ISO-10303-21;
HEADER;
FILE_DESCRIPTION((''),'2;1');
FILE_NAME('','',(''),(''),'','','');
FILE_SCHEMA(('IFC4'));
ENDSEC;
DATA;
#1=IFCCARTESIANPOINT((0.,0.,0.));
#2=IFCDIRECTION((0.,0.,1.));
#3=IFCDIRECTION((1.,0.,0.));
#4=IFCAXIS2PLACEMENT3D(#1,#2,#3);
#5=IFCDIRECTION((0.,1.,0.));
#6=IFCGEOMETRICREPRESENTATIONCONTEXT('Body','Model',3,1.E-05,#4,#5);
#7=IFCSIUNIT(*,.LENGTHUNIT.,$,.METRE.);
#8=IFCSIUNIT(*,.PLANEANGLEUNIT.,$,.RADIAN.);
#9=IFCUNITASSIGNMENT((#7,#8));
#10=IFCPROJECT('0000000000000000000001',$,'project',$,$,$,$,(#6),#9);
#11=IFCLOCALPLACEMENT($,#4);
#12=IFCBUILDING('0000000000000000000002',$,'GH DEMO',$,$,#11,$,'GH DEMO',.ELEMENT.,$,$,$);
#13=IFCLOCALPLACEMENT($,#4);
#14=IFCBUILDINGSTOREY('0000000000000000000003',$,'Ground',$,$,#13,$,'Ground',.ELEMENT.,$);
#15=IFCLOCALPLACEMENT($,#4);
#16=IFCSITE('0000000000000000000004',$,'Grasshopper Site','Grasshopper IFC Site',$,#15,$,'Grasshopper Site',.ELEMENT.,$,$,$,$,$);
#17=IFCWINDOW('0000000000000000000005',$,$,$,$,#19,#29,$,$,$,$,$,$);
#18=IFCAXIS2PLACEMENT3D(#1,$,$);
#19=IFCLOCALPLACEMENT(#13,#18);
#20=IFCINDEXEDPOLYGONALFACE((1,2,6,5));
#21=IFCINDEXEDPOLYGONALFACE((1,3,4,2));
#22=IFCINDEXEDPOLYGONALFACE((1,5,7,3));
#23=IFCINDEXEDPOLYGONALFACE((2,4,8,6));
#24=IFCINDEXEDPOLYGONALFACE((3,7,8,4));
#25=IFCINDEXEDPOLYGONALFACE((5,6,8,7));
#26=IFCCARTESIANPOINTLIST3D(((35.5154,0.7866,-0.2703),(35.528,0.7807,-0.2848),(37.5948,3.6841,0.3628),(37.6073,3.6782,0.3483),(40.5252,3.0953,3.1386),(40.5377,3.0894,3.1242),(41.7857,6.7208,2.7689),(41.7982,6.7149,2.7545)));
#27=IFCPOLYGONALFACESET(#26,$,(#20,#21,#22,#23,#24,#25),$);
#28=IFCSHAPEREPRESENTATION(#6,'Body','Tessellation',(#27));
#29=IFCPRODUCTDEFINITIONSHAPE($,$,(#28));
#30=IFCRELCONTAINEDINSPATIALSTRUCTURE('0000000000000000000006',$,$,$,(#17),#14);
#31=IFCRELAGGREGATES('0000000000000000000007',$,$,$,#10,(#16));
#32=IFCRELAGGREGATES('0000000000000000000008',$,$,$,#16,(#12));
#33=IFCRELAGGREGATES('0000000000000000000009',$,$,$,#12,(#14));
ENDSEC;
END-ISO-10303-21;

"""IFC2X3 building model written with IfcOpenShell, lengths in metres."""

from ifc_helpers import new_model, si_unit, direction, frame, origin_with_axes, place, context, project, spatial, polyline, outline, extrude, element, save


model = new_model("IFC2X3")

# Units and contexts
model_context = context("Model", 3, precision=1e-05, world=origin_with_axes(), true_north=direction((0.0, 1.0, 0.0)), identifier="Body")
ifc_project = project(units=[si_unit("LENGTHUNIT", "METRE"), si_unit("PLANEANGLEUNIT", "RADIAN")], contexts=[model_context])

# Site, building, storey
site_placement = place(None, origin_with_axes())
site = spatial("IfcSite", under=ifc_project, at=site_placement, Name="Grasshopper Site", Description="Grasshopper IFC Site", LongName="Grasshopper Site", CompositionType="ELEMENT")
building_placement = place(None, origin_with_axes())
building = spatial("IfcBuilding", under=site, at=building_placement, Name="GH DEMO", LongName="GH DEMO", CompositionType="ELEMENT")
storey_placement = place(None, origin_with_axes())
storey = spatial("IfcBuildingStorey", under=building, at=storey_placement, Name="Ground", LongName="Ground", CompositionType="ELEMENT")

# Window
window_1_placement = place(None, origin_with_axes())
element("IfcWindow", 1, at=window_1_placement, inside=storey, context=model_context, shape_type="SweptSolid", body=[
    extrude(outline(polyline([(0.0, 0.0), (5.7074, 0.0), (3.0087, 2.7544), (-3.3354, 1.4125), (0.0, 0.0)])), frame((37.5948, 3.6841, 0.3628), z_axis=(0.626319, -0.291483, -0.723023), x_axis=(0.734289, 0.532061, 0.421581)), (0.0, 0.0, 1.0), 0.02),
])

save(model, "model.ifc")
